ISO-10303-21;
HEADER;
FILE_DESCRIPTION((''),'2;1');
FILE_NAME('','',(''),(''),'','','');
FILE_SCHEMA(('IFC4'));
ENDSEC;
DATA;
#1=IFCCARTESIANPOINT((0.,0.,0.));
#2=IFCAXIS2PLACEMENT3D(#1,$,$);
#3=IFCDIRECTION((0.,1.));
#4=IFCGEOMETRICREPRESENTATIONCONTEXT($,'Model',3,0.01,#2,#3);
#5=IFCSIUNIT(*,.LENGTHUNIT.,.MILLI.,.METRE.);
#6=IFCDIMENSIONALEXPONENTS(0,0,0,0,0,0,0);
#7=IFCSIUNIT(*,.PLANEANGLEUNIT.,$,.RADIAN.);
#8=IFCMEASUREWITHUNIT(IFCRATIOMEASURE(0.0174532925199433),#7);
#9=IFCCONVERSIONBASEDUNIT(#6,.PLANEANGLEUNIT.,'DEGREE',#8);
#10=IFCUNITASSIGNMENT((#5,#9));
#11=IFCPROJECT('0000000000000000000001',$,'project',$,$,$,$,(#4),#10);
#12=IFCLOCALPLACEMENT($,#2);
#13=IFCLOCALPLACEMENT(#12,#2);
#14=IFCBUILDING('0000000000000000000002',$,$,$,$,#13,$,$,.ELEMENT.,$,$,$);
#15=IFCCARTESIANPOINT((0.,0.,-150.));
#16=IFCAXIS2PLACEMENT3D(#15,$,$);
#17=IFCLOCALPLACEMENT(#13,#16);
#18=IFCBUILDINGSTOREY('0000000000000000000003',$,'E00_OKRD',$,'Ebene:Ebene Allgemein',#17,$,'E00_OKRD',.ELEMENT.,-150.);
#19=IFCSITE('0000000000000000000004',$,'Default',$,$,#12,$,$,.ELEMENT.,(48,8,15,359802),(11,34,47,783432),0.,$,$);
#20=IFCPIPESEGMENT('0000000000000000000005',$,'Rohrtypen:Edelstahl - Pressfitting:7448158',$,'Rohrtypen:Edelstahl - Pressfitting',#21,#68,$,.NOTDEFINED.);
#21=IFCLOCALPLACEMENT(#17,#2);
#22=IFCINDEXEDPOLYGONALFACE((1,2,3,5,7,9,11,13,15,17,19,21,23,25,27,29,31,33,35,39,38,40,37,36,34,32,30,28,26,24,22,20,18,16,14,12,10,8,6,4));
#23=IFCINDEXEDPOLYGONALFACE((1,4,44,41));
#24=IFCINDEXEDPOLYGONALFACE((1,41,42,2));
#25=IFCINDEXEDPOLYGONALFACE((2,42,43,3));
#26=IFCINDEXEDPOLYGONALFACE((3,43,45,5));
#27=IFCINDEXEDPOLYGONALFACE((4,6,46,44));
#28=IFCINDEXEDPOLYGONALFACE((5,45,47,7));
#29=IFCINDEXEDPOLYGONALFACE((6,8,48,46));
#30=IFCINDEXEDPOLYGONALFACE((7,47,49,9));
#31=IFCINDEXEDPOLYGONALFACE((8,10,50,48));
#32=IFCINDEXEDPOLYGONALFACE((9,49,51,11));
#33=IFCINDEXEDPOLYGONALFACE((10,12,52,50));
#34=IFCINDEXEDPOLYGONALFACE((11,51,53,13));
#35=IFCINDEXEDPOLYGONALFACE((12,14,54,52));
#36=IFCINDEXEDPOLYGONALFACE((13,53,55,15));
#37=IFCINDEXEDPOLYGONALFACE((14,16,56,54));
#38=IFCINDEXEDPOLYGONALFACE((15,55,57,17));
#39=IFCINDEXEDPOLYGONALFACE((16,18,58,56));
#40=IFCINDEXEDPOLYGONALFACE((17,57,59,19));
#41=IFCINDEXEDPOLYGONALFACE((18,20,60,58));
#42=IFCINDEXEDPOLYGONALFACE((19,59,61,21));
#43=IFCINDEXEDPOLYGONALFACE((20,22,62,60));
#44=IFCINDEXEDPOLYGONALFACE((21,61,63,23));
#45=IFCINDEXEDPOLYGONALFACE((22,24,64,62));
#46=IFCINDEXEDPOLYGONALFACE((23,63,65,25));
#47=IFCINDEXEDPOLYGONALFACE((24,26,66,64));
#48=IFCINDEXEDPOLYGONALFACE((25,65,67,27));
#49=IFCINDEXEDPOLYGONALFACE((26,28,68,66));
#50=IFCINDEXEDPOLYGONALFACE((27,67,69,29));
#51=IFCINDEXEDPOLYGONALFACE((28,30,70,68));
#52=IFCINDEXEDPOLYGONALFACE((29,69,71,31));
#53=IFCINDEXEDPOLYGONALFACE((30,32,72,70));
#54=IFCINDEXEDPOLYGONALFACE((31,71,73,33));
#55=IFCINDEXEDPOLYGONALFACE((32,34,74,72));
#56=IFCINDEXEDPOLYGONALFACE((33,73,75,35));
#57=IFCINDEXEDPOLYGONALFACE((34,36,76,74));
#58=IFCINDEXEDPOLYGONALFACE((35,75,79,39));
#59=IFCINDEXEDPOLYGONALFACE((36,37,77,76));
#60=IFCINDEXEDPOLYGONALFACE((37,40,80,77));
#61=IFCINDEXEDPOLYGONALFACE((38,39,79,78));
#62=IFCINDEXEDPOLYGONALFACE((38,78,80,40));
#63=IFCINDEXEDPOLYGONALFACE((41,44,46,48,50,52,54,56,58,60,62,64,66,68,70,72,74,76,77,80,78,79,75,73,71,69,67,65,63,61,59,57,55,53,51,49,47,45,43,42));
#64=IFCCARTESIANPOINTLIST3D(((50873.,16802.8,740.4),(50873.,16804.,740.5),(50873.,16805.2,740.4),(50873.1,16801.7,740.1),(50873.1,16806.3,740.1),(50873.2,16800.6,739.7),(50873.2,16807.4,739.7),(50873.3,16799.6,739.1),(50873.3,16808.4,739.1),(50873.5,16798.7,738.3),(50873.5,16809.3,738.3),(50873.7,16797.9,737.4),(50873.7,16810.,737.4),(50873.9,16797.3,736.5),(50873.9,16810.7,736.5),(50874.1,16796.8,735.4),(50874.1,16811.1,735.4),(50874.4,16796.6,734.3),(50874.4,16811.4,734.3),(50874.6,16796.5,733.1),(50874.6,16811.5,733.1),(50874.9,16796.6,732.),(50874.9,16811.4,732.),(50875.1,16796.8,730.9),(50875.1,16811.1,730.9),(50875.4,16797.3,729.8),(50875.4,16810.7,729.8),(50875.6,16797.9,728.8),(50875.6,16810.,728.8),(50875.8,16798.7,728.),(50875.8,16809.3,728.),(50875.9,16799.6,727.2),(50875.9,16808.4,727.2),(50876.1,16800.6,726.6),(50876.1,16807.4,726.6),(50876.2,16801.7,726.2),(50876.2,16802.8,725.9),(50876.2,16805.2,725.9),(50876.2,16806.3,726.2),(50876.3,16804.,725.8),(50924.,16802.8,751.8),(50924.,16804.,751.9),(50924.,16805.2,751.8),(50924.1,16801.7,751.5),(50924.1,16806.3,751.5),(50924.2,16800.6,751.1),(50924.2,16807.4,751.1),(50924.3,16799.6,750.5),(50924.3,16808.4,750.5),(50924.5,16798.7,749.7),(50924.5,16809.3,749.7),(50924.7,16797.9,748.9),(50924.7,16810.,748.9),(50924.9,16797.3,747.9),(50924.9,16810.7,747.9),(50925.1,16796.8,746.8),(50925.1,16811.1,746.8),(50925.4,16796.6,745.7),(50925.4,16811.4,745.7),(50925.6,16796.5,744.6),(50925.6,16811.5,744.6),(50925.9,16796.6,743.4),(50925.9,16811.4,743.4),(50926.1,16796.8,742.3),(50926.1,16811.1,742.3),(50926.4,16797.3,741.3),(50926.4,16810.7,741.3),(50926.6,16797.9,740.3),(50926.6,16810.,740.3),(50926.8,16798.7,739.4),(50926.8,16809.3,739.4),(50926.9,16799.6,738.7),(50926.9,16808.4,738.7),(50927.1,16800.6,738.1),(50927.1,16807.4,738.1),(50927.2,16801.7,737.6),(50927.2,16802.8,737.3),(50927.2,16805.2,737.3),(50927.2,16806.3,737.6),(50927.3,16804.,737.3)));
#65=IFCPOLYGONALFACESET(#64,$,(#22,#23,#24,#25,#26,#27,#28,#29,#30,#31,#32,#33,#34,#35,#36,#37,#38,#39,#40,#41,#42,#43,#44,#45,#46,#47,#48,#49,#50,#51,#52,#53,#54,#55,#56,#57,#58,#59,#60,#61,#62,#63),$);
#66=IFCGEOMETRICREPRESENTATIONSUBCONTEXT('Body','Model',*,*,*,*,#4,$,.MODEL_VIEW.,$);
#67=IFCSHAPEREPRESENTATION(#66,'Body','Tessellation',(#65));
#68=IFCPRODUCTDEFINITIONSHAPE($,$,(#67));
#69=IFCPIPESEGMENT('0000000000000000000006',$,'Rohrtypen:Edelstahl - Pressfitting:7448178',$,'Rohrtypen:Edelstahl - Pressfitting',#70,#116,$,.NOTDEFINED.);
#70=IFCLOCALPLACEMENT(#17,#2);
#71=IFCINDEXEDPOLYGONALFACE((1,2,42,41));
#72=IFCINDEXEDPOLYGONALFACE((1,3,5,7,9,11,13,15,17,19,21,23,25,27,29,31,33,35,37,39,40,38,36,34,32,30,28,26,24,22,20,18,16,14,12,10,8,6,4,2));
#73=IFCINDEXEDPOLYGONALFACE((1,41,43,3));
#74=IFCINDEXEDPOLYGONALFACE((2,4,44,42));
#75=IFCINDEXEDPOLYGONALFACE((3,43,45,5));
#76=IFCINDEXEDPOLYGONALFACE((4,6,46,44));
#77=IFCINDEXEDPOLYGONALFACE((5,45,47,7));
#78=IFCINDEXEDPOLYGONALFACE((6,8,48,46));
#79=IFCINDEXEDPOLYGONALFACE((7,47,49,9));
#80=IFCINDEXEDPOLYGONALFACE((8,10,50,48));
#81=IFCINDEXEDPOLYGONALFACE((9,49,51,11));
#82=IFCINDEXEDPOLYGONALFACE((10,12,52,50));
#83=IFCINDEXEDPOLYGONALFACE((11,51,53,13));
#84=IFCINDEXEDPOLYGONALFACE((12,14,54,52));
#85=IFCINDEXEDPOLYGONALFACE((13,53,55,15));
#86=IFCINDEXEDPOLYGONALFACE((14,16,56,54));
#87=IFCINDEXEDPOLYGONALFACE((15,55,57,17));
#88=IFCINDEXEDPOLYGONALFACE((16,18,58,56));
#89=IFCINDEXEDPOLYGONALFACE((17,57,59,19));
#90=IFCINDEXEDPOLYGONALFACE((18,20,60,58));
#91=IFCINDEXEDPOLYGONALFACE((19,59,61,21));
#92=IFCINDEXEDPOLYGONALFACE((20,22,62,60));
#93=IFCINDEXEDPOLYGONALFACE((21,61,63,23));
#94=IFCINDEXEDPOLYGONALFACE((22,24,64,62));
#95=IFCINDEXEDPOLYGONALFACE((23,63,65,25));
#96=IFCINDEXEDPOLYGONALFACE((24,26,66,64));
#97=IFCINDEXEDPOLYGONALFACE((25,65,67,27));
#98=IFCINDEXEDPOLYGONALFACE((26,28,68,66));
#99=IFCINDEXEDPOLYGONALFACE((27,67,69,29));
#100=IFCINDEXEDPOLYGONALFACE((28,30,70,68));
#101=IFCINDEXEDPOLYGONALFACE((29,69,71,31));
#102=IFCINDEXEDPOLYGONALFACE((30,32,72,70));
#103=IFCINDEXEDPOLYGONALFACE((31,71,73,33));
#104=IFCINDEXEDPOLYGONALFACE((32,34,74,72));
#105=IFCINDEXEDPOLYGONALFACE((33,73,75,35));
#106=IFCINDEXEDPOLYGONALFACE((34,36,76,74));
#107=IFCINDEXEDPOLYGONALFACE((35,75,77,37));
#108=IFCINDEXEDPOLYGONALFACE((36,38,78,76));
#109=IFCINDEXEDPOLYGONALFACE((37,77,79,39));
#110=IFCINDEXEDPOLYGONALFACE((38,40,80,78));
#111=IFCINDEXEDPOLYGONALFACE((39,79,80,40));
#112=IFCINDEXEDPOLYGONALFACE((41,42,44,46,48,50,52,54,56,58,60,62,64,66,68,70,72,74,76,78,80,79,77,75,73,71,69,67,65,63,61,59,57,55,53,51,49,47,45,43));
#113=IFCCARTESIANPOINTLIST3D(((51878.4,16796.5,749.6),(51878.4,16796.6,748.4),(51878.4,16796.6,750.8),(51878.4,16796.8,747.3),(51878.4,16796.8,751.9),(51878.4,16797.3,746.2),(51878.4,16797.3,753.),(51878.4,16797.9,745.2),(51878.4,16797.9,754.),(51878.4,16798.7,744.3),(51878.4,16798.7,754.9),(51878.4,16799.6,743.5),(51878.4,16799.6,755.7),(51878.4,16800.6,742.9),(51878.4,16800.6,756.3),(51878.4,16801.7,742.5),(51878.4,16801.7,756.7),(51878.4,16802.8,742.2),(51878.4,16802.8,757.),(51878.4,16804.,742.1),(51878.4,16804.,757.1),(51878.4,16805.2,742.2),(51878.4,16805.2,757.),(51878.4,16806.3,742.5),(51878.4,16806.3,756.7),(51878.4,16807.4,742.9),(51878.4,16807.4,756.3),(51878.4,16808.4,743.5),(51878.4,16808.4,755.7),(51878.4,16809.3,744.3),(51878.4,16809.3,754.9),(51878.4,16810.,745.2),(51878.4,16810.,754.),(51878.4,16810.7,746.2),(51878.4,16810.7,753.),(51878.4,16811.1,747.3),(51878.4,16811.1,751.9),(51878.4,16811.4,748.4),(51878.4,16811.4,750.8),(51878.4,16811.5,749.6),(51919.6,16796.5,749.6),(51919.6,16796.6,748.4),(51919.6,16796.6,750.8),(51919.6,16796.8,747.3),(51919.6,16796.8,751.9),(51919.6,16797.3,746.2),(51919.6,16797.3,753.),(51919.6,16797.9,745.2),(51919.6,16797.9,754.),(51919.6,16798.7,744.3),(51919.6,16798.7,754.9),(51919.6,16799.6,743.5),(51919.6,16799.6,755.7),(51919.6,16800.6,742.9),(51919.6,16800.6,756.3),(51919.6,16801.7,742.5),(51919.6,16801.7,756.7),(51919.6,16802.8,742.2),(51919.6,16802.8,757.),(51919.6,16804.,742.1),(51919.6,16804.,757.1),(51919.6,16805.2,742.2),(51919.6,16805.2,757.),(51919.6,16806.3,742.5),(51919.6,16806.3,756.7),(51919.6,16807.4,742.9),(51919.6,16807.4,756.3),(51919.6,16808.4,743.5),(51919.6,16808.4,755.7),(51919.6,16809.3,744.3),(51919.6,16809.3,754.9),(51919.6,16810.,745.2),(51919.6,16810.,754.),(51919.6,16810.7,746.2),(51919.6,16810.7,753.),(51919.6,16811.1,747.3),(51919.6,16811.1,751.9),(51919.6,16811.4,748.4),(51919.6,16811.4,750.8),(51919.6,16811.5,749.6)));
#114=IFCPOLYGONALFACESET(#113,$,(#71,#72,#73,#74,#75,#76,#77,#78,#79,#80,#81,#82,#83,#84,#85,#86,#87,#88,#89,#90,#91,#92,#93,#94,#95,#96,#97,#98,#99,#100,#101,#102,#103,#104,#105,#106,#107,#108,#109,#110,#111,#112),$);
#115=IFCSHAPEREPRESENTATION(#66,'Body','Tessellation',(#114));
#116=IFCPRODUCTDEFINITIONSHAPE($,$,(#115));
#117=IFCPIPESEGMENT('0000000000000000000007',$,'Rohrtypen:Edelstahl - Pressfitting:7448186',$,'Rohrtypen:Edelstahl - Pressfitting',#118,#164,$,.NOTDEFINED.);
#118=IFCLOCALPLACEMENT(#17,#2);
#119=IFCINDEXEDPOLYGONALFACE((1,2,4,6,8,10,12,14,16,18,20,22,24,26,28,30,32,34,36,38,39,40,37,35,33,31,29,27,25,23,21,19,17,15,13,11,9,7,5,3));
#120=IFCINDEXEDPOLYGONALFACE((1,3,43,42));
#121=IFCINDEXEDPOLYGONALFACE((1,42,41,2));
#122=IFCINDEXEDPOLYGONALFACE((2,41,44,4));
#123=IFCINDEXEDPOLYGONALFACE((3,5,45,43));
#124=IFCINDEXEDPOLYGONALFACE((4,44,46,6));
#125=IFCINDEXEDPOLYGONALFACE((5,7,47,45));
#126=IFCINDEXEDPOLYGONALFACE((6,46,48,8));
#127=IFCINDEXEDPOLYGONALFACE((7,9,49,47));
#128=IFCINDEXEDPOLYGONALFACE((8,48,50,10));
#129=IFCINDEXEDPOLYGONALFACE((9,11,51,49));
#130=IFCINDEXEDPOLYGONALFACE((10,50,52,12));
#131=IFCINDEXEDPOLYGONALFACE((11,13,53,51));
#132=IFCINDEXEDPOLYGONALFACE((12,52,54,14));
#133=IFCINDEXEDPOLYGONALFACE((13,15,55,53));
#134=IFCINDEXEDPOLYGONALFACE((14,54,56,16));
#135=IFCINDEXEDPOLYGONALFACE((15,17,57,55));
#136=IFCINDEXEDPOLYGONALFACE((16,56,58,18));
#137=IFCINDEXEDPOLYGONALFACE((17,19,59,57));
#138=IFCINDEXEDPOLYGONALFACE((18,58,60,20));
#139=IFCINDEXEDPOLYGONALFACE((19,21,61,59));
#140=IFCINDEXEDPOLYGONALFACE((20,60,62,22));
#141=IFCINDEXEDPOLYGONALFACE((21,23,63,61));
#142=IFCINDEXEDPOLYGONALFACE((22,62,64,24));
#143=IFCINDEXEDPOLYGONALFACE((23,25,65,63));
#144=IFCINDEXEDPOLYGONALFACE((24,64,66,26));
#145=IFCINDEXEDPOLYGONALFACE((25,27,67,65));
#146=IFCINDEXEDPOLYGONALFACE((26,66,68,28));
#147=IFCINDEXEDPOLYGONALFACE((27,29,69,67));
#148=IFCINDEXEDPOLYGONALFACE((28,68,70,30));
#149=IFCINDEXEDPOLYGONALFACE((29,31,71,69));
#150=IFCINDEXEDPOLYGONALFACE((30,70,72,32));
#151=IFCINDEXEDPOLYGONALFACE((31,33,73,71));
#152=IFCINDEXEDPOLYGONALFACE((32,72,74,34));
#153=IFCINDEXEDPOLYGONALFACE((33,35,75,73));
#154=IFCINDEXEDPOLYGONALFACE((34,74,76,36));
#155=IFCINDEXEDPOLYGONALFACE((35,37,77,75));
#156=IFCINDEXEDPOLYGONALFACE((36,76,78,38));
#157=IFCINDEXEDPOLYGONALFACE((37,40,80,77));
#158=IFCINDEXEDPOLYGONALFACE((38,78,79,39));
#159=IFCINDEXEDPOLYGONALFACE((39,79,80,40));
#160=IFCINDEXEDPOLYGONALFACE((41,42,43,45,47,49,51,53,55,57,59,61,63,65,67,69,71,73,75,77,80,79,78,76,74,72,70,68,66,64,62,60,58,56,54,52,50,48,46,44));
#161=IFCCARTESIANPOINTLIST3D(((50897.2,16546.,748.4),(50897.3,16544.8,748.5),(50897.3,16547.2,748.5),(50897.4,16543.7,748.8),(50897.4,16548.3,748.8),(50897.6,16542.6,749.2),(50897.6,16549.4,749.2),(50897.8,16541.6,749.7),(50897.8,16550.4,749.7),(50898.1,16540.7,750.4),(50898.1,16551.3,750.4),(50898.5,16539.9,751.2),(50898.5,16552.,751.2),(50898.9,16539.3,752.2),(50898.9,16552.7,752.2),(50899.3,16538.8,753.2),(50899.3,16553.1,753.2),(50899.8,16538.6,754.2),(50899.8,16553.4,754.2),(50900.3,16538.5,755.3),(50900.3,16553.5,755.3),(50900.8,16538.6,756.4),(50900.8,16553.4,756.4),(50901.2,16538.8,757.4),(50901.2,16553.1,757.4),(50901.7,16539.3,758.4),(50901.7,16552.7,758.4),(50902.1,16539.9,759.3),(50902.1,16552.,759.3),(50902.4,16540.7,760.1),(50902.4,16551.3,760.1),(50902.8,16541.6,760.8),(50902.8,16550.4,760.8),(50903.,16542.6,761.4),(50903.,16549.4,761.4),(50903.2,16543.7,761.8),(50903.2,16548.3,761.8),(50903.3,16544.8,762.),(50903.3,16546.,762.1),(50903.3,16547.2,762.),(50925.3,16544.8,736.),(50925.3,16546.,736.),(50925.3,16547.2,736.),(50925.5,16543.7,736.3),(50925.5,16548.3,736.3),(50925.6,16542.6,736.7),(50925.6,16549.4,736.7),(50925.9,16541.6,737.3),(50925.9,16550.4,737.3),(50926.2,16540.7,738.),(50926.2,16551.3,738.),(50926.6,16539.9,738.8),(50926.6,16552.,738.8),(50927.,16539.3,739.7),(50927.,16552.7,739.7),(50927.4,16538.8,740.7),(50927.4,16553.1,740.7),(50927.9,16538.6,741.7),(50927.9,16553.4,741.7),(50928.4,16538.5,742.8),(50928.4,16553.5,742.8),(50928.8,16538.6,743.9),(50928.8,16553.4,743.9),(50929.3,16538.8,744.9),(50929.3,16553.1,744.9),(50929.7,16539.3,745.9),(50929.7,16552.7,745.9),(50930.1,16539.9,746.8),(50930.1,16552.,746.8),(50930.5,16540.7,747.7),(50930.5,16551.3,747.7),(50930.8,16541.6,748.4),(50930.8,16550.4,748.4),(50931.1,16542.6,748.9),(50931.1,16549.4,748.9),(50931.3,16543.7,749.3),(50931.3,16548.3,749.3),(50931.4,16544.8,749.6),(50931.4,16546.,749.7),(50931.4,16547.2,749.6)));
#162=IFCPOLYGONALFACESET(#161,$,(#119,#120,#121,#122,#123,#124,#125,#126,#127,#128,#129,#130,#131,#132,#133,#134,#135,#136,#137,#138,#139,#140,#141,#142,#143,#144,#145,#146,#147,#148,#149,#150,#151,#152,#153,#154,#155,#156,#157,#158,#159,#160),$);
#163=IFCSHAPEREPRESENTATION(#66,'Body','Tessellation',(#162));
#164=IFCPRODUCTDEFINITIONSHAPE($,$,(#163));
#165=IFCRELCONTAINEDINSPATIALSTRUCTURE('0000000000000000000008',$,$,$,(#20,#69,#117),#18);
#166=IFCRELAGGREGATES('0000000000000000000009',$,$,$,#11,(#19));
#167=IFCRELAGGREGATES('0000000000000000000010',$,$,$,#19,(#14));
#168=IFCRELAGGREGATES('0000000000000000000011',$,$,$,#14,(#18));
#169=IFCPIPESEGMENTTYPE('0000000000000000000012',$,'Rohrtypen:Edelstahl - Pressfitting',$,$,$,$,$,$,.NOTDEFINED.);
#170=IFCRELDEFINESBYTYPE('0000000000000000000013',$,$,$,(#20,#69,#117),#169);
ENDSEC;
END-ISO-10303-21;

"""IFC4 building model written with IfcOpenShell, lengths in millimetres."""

from ifc_helpers import new_model, entity, si_unit, converted_unit, direction, frame, origin, place, context, subcontext, project, spatial, indexed_curve, outline, extrude, type_object, element, save


model = new_model("IFC4")

# Units and contexts
model_context = context("Model", 3, precision=0.01, world=origin(), true_north=direction((0.0, 1.0)))
body_context = subcontext(model_context, "Body", "Model", "MODEL_VIEW")
ifc_project = project(units=[si_unit("LENGTHUNIT", "METRE", prefix="MILLI"), converted_unit("PLANEANGLEUNIT", "DEGREE", entity("IfcRatioMeasure", 0.0174532925199433), si_unit("PLANEANGLEUNIT", "RADIAN"), dimensions=[0, 0, 0, 0, 0, 0, 0])], contexts=[model_context])

# Site, building, storey
site_placement = place(None, origin())
site = spatial("IfcSite", under=ifc_project, at=site_placement, Name="Default", CompositionType="ELEMENT", RefLatitude=(48, 8, 15, 359802), RefLongitude=(11, 34, 47, 783432), RefElevation=0.0)
building_placement = place(site_placement, origin())
building = spatial("IfcBuilding", under=site, at=building_placement, CompositionType="ELEMENT")
storey_placement = place(building_placement, frame((0.0, 0.0, -150.0)))
storey = spatial("IfcBuildingStorey", under=building, at=storey_placement, Name="E00_OKRD", ObjectType="Ebene:Ebene Allgemein", LongName="E00_OKRD", CompositionType="ELEMENT", Elevation=-150.0)

# Pipe segments
pipe_segment_type_1 = type_object("IfcPipeSegmentType", Name="Rohrtypen:Edelstahl - Pressfitting", PredefinedType="NOTDEFINED")
pipe_segment_1_placement = place(storey_placement, origin())
element("IfcPipeSegment", 1, at=pipe_segment_1_placement, inside=storey, type_object=pipe_segment_type_1, Name="Rohrtypen:Edelstahl - Pressfitting:7448158", ObjectType="Rohrtypen:Edelstahl - Pressfitting", PredefinedType="NOTDEFINED", context=body_context, shape_type="SweptSolid", body=[
    extrude(outline(indexed_curve([(7.5, 0.0), (7.4, 1.2), (7.1, 2.3), (6.7, 3.4), (6.1, 4.4), (5.3, 5.3), (4.4, 6.1), (3.4, 6.7), (2.3, 7.1), (1.2, 7.4), (0.0, 7.5), (-1.2, 7.4), (-2.3, 7.1), (-3.4, 6.7), (-4.4, 6.1), (-5.3, 5.3), (-6.1, 4.4), (-6.7, 3.4), (-7.1, 2.3), (-7.4, 1.2), (-7.5, 0.0), (-7.4, -1.2), (-7.1, -2.3), (-6.7, -3.4), (-6.1, -4.4), (-5.3, -5.3), (-4.4, -6.1), (-3.4, -6.7), (-2.3, -7.1), (-1.2, -7.4), (0.0, -7.5), (1.2, -7.4), (2.3, -7.1), (3.4, -6.7), (4.4, -6.1), (5.3, -5.3), (6.1, -4.4), (6.7, -3.4), (7.1, -2.3), (7.4, -1.2), (7.5, 0.0)], self_intersect=False)), frame((50874.6, 16804.0, 733.1), z_axis=(0.975818, 0.0, 0.218583), x_axis=(0.0, -1.0, 0.0)), (0.0, 0.0, 1.0), 52.3),
])
pipe_segment_2_placement = place(storey_placement, origin())
element("IfcPipeSegment", 2, at=pipe_segment_2_placement, inside=storey, type_object=pipe_segment_type_1, Name="Rohrtypen:Edelstahl - Pressfitting:7448178", ObjectType="Rohrtypen:Edelstahl - Pressfitting", PredefinedType="NOTDEFINED", context=body_context, shape_type="SweptSolid", body=[
    extrude(outline(indexed_curve([(7.5, 0.0), (7.4, 1.2), (7.1, 2.3), (6.7, 3.4), (6.1, 4.4), (5.3, 5.3), (4.4, 6.1), (3.4, 6.7), (2.3, 7.1), (1.2, 7.4), (0.0, 7.5), (-1.2, 7.4), (-2.3, 7.1), (-3.4, 6.7), (-4.4, 6.1), (-5.3, 5.3), (-6.1, 4.4), (-6.7, 3.4), (-7.1, 2.3), (-7.4, 1.2), (-7.5, 0.0), (-7.4, -1.2), (-7.1, -2.3), (-6.7, -3.4), (-6.1, -4.4), (-5.3, -5.3), (-4.4, -6.1), (-3.4, -6.7), (-2.3, -7.1), (-1.2, -7.4), (0.0, -7.5), (1.2, -7.4), (2.3, -7.1), (3.4, -6.7), (4.4, -6.1), (5.3, -5.3), (6.1, -4.4), (6.7, -3.4), (7.1, -2.3), (7.4, -1.2), (7.5, 0.0)], self_intersect=False)), frame((51878.4, 16804.0, 749.6), z_axis=(1.0, 0.0, 0.0), x_axis=(0.0, 1.0, 0.0)), (0.0, 0.0, 1.0), 41.2),
])
pipe_segment_3_placement = place(storey_placement, origin())
element("IfcPipeSegment", 3, at=pipe_segment_3_placement, inside=storey, type_object=pipe_segment_type_1, Name="Rohrtypen:Edelstahl - Pressfitting:7448186", ObjectType="Rohrtypen:Edelstahl - Pressfitting", PredefinedType="NOTDEFINED", context=body_context, shape_type="SweptSolid", body=[
    extrude(outline(indexed_curve([(7.5, 0.0), (7.4, 1.2), (7.1, 2.3), (6.7, 3.4), (6.1, 4.4), (5.3, 5.3), (4.4, 6.1), (3.4, 6.7), (2.3, 7.1), (1.2, 7.4), (0.0, 7.5), (-1.2, 7.4), (-2.3, 7.1), (-3.4, 6.7), (-4.4, 6.1), (-5.3, 5.3), (-6.1, 4.4), (-6.7, 3.4), (-7.1, 2.3), (-7.4, 1.2), (-7.5, 0.0), (-7.4, -1.2), (-7.1, -2.3), (-6.7, -3.4), (-6.1, -4.4), (-5.3, -5.3), (-4.4, -6.1), (-3.4, -6.7), (-2.3, -7.1), (-1.2, -7.4), (0.0, -7.5), (1.2, -7.4), (2.3, -7.1), (3.4, -6.7), (4.4, -6.1), (5.3, -5.3), (6.1, -4.4), (6.7, -3.4), (7.1, -2.3), (7.4, -1.2), (7.5, 0.0)], self_intersect=False)), frame((50928.4, 16546.0, 742.8), z_axis=(-0.913932, 0.0, 0.405867), x_axis=(0.0, -1.0, 0.0)), (0.0, 0.0, 1.0), 30.7),
])

save(model, "model.ifc")
